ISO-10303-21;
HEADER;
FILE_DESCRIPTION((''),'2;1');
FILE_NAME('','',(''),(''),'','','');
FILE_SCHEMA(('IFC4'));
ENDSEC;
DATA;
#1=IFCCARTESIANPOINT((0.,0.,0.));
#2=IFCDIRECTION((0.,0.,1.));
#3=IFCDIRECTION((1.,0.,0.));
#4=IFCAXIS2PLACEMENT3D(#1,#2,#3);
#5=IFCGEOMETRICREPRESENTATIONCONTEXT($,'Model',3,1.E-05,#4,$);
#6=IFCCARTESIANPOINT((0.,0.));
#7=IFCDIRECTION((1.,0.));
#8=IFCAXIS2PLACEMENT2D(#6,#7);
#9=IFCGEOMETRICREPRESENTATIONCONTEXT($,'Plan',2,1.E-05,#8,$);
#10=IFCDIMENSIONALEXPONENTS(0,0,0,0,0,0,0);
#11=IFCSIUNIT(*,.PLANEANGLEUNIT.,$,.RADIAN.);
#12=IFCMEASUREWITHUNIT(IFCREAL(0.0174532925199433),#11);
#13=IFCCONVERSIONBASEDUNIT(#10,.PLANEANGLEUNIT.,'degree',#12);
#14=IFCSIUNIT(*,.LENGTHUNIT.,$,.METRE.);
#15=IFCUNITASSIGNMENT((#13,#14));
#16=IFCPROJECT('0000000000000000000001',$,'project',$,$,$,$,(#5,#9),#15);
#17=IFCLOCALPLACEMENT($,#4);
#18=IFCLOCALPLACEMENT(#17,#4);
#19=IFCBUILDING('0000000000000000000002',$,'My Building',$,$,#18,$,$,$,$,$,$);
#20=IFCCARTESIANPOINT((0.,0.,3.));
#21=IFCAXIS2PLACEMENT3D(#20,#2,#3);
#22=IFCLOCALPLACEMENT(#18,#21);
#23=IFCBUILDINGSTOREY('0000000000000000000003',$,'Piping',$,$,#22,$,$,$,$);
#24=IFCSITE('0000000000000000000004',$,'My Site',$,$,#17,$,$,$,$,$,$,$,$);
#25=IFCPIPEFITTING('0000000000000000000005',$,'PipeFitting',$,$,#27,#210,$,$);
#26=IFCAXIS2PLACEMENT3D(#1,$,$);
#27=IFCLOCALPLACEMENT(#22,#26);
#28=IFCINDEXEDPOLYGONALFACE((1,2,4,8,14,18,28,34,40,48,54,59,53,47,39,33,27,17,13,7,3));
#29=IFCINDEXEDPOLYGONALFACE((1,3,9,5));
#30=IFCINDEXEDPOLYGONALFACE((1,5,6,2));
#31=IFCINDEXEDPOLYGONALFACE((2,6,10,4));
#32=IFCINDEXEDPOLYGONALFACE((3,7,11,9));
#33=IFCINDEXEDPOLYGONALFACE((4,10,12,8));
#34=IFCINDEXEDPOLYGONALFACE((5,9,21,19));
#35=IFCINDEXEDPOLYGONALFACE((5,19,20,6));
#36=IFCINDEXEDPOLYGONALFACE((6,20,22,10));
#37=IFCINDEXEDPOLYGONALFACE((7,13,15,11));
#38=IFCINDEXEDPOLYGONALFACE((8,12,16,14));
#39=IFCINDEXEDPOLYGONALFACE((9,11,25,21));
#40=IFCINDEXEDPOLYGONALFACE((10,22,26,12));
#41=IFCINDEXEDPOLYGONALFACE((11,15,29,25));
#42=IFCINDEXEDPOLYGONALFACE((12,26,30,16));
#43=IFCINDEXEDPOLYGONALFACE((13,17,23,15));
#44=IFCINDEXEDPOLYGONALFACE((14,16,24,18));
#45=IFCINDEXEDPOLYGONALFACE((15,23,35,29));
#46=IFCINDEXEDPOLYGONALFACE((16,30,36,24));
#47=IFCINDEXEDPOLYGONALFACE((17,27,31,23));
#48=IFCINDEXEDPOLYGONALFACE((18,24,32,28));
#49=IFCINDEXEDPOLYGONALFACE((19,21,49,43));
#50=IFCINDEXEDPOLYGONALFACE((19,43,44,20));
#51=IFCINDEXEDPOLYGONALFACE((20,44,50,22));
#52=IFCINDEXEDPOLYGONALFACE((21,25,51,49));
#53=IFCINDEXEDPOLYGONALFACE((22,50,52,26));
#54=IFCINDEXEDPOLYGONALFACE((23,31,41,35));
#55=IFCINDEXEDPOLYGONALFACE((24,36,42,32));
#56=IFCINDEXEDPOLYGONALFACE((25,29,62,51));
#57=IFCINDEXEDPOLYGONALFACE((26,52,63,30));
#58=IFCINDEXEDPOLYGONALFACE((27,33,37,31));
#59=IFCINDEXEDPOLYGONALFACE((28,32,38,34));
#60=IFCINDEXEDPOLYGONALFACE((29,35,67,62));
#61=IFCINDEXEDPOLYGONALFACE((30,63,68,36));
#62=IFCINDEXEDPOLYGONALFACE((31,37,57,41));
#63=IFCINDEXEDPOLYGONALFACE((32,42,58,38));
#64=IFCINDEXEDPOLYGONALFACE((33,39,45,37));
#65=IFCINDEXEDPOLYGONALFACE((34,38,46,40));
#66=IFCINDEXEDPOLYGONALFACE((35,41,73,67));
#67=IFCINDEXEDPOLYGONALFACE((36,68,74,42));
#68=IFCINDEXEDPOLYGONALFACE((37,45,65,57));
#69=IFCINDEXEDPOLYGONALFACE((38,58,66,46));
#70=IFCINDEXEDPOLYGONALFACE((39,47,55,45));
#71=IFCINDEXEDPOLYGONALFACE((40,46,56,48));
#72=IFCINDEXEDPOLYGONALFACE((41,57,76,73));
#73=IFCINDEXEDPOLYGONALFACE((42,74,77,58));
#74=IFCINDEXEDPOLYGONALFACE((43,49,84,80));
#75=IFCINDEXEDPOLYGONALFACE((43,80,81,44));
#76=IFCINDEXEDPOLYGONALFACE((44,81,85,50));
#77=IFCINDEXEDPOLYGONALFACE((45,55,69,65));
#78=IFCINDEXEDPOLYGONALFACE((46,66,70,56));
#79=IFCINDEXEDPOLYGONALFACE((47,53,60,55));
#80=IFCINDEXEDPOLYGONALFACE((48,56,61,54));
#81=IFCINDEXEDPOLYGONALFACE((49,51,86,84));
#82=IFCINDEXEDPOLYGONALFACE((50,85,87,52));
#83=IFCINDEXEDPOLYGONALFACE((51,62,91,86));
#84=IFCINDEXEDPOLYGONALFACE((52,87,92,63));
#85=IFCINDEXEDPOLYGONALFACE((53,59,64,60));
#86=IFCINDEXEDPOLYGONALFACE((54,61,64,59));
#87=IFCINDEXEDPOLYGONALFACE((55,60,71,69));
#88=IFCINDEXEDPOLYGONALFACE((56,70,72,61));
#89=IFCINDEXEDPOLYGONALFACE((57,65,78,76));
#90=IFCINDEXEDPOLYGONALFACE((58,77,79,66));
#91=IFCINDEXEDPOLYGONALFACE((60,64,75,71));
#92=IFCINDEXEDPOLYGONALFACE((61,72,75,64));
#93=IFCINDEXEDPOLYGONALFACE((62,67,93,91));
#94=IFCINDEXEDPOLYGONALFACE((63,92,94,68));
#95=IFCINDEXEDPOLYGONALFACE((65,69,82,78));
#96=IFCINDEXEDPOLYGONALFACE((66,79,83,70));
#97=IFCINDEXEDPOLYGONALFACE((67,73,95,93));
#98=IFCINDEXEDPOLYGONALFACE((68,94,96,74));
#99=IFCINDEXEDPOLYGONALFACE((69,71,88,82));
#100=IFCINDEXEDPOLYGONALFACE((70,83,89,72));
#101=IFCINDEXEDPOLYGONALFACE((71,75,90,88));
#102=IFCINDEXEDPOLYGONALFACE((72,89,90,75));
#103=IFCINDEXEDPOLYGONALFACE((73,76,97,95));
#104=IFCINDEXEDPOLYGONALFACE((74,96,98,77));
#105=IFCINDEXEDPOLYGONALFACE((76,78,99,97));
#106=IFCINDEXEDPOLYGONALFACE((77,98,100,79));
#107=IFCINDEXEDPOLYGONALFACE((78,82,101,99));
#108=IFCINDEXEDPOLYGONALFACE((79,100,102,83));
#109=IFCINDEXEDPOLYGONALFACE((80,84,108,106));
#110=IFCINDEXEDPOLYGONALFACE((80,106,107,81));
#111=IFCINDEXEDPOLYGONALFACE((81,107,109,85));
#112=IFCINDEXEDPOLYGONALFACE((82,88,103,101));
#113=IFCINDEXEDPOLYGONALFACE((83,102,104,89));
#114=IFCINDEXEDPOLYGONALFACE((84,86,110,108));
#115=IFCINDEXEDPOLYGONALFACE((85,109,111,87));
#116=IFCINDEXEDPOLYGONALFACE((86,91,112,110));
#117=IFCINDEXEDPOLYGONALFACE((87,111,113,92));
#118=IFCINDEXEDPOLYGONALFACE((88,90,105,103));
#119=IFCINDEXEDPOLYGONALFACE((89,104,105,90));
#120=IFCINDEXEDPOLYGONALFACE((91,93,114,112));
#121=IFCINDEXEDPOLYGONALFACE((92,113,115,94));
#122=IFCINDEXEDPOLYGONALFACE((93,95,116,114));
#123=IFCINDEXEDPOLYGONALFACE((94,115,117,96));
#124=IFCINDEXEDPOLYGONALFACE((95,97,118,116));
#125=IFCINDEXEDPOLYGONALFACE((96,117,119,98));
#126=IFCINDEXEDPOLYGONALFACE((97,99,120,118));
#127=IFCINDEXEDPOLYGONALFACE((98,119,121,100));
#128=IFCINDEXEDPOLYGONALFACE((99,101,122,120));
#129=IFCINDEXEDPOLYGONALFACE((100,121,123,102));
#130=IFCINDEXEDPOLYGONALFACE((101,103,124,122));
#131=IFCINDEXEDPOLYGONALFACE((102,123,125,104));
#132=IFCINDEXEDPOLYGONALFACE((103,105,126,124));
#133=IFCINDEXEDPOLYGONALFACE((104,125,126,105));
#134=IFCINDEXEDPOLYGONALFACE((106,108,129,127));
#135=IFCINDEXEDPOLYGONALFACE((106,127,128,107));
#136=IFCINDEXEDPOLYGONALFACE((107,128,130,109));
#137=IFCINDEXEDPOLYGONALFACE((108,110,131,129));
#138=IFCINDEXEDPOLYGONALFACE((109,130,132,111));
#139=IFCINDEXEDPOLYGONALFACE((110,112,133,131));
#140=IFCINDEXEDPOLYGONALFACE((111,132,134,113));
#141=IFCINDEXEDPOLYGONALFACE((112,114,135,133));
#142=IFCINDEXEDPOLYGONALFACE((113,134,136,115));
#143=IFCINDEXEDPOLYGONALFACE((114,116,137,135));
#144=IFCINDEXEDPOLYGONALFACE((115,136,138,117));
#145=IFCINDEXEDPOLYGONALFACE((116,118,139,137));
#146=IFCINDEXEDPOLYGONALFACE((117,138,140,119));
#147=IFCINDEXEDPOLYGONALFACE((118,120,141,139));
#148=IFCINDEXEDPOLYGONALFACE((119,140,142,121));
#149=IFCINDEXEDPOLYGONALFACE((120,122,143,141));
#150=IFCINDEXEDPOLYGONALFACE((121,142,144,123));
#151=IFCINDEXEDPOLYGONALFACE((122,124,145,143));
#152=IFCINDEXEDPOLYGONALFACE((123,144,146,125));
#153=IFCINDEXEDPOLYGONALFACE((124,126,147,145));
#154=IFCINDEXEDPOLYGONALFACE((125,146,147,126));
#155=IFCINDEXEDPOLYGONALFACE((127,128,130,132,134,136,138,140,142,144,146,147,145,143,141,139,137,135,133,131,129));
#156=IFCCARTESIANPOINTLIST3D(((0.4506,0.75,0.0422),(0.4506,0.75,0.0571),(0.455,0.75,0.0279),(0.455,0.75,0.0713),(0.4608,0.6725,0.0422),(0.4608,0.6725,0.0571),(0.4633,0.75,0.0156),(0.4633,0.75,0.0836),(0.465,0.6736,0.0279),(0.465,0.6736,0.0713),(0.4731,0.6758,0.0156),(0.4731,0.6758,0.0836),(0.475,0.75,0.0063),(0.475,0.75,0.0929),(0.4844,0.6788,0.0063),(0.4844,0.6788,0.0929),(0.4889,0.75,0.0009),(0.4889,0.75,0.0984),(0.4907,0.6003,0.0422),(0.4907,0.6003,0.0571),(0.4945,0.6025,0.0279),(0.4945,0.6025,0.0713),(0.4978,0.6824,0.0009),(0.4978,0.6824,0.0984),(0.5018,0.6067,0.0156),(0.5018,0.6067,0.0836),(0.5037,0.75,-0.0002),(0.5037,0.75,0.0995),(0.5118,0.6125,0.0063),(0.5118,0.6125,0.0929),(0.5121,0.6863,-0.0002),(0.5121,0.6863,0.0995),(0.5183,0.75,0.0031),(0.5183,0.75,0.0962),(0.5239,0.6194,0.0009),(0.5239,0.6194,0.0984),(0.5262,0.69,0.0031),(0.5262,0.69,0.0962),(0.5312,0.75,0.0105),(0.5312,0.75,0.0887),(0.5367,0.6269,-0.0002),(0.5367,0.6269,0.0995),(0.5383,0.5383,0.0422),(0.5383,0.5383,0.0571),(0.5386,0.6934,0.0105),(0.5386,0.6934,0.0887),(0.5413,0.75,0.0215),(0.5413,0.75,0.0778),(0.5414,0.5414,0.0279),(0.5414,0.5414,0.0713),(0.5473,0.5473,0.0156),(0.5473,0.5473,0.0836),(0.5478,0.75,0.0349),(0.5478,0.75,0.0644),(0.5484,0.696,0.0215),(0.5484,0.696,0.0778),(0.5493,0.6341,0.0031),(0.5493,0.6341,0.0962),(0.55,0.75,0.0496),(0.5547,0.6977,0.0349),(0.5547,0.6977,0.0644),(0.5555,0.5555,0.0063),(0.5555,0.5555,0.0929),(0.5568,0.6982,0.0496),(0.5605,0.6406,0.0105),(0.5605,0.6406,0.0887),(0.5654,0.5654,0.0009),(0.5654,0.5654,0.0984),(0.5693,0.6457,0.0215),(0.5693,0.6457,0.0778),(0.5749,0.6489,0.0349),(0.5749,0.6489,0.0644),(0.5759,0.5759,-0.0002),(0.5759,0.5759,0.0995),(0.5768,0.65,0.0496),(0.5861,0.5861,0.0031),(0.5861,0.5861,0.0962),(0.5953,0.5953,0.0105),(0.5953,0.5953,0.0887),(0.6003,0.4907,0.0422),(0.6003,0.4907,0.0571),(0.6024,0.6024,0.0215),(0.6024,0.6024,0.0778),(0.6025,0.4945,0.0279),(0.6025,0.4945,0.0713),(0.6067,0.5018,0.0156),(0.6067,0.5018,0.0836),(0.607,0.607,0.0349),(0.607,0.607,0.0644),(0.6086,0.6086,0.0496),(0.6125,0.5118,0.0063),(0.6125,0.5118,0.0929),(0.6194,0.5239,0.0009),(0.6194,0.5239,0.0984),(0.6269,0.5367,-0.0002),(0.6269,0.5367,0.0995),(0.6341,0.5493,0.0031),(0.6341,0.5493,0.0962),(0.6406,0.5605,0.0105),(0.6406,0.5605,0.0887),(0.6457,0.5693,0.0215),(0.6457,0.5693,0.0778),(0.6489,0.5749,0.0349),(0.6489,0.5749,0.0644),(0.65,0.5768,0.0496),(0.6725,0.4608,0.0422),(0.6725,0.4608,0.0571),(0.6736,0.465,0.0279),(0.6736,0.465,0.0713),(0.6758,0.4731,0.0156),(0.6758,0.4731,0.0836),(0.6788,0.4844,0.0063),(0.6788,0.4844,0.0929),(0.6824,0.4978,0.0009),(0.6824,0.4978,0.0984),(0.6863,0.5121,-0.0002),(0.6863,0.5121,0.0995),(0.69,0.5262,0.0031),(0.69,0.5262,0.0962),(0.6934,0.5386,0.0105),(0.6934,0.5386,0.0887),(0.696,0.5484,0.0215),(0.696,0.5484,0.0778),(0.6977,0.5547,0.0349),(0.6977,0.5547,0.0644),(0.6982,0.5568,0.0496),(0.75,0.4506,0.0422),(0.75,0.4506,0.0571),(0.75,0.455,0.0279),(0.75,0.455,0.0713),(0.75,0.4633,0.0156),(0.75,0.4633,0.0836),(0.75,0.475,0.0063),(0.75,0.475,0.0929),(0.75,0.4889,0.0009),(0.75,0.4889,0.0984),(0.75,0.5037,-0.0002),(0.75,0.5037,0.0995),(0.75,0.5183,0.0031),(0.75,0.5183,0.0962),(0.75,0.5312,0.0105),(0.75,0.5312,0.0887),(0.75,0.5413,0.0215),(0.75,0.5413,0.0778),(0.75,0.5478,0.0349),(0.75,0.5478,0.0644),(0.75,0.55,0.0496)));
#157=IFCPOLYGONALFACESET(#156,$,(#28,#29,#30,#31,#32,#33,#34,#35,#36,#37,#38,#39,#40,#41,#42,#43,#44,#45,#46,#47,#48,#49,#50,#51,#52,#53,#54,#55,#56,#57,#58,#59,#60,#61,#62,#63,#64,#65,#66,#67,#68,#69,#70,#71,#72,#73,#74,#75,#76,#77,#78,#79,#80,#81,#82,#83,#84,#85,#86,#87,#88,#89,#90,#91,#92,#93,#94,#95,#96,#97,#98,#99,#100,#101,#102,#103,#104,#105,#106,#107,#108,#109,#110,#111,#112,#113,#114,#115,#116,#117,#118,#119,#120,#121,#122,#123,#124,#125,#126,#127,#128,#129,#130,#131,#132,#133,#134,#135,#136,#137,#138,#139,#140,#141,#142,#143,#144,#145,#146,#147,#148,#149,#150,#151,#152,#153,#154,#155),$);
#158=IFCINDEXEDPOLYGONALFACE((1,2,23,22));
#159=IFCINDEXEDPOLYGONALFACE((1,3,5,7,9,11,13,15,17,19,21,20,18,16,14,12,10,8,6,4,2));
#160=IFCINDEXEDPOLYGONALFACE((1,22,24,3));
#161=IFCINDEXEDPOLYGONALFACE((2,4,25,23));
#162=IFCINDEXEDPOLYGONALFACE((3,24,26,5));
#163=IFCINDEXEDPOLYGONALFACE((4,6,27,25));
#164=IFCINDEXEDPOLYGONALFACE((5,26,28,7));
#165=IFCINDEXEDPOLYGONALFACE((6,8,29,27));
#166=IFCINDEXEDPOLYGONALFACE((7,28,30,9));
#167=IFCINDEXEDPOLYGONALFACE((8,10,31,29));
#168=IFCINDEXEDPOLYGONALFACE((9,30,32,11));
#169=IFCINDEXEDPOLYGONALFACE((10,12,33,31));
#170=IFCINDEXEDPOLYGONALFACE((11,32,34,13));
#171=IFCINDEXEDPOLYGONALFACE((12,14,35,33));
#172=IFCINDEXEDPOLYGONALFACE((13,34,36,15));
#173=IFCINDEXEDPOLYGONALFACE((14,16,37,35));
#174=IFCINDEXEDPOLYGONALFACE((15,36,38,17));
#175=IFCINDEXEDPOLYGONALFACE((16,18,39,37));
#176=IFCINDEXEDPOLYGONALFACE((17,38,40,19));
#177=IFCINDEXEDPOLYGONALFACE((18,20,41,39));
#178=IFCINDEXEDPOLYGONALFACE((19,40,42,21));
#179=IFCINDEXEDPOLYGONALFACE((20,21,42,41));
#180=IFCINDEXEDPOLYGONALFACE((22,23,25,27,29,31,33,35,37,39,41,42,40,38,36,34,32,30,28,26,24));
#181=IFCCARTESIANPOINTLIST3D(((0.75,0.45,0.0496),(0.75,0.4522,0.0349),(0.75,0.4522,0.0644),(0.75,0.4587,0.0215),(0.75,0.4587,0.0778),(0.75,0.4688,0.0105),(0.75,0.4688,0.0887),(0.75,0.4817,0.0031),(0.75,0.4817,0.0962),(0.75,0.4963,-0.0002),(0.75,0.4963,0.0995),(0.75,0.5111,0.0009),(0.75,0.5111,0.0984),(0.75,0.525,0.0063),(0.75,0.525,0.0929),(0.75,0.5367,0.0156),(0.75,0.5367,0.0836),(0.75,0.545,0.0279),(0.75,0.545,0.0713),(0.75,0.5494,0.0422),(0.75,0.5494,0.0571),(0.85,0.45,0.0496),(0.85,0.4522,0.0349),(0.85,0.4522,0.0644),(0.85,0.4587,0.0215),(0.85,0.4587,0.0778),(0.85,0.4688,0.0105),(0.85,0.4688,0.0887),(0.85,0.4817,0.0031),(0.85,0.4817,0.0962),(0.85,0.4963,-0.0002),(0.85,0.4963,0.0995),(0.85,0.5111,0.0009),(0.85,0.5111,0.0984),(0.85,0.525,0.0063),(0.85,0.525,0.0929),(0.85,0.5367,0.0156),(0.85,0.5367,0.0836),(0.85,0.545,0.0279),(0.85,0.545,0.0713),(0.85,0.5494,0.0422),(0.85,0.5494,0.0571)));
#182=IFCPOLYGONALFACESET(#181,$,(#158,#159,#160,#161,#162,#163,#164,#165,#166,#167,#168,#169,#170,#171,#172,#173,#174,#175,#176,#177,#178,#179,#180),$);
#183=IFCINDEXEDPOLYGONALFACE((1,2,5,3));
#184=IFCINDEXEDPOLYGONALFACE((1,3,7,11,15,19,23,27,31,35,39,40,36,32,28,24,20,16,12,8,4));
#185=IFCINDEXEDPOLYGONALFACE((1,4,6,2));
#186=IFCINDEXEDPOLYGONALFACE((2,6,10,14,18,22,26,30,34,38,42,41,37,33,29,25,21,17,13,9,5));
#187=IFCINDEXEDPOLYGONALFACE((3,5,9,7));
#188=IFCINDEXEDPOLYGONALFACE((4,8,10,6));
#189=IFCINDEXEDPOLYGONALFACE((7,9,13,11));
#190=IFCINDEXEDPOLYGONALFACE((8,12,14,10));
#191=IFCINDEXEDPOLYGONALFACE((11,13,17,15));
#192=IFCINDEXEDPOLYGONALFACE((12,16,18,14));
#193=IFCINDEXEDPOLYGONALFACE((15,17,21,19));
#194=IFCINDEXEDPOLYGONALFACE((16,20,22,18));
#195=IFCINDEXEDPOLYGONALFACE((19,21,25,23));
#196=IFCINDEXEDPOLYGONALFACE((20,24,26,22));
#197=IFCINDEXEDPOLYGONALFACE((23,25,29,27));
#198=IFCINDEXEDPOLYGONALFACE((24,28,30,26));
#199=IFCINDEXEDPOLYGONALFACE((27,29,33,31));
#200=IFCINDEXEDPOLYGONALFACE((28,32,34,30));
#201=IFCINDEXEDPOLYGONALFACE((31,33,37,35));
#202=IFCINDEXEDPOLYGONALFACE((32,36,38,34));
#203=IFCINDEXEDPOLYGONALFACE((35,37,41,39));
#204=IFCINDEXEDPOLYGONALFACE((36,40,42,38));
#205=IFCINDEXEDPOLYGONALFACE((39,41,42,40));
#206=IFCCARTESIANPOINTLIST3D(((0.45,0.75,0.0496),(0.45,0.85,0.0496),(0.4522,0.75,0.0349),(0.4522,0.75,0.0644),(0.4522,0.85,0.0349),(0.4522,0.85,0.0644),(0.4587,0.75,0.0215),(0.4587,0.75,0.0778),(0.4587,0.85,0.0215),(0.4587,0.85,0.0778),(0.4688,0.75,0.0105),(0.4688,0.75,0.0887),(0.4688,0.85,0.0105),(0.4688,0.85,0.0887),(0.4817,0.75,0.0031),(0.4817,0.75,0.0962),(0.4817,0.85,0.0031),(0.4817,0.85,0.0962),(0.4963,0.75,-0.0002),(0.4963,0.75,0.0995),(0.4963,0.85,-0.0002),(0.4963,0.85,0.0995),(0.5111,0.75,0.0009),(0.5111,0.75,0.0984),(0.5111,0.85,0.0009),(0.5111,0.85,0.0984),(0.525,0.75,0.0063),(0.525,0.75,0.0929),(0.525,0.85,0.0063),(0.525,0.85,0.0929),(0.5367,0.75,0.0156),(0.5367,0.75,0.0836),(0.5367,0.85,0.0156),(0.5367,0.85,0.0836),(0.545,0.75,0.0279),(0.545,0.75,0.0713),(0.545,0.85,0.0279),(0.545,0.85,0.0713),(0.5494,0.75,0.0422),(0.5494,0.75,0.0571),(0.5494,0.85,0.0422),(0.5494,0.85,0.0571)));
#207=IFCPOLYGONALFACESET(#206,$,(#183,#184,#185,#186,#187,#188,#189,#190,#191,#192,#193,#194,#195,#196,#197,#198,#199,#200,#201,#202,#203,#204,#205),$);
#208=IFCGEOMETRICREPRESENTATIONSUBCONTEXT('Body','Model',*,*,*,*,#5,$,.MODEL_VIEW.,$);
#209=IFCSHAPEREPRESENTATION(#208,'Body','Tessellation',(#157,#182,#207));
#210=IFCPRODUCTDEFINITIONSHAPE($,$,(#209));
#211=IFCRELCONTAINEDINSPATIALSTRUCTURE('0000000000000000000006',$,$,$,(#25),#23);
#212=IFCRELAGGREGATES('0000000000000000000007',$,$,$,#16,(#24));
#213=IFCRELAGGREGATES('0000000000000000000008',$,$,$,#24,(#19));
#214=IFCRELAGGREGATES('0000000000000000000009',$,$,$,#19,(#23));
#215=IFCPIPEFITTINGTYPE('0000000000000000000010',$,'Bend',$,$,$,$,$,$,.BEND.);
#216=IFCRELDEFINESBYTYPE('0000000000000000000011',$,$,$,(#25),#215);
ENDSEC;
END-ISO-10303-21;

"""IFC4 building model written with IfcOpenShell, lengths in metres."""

from ifc_helpers import new_model, entity, si_unit, converted_unit, frame, origin_with_axes, origin_2d_with_axis, place, context, subcontext, project, spatial, circle, extrude, source, transform, mapped, type_object, type_shapes, element, save


model = new_model("IFC4")

# Units and contexts
model_context = context("Model", 3, precision=1e-05, world=origin_with_axes())
plan_context = context("Plan", 2, precision=1e-05, world=origin_2d_with_axis())
body_context = subcontext(model_context, "Body", "Model", "MODEL_VIEW")
ifc_project = project(units=[converted_unit("PLANEANGLEUNIT", "degree", entity("IfcReal", 0.0174532925199433), si_unit("PLANEANGLEUNIT", "RADIAN"), dimensions=[0, 0, 0, 0, 0, 0, 0]), si_unit("LENGTHUNIT", "METRE")], contexts=[model_context, plan_context])

# Site, building, storey
site_placement = place(None, origin_with_axes())
site = spatial("IfcSite", under=ifc_project, at=site_placement, Name="My Site")
building_placement = place(site_placement, origin_with_axes())
building = spatial("IfcBuilding", under=site, at=building_placement, Name="My Building")
storey_placement = place(building_placement, frame((0.0, 0.0, 3.0), z_axis=(0.0, 0.0, 1.0), x_axis=(1.0, 0.0, 0.0)))
storey = spatial("IfcBuildingStorey", under=building, at=storey_placement, Name="Piping")

# Pipe fitting
pipe_fitting_type_1 = type_object("IfcPipeFittingType", Name="Bend", PredefinedType="BEND")
shared_shape = source(origin_with_axes(), body_context, "Body", "SolidModel", [
    entity("IfcSweptDiskSolid", entity("IfcIndexedPolyCurve", entity("IfcCartesianPointList3D", [[0.0, 0.0, -0.1], [-0.0732, 0.0, -0.2768], [-0.25, 0.0, -0.35]]), [entity("IfcArcIndex", [1, 2, 3])]), 0.05),
    extrude(circle(Radius=0.05), origin_with_axes(), (0.0, 0.0, -1.0), 0.1),
    extrude(circle(Radius=0.05), frame((-0.25, 0.0, -0.35), z_axis=(-1.0, 0.0, 0.0), x_axis=(0.0, 0.0, -1.0)), (0.0, 0.0, 1.0), 0.1),
])
type_shapes(pipe_fitting_type_1, [shared_shape])
for number, where, z_axis, x_axis, name in (
    (1, (0.85, 0.5, 0.0496), (1.0, 0.000001, -0.000001), (0.000001, -1.0, 0.0), "PipeFitting"),
):
    element("IfcPipeFitting", number, at=place(storey_placement, frame(where, z_axis=z_axis, x_axis=x_axis)), inside=storey, type_object=pipe_fitting_type_1, Name=name, context=body_context, shape_type="MappedRepresentation", body=[
        mapped(shared_shape, transform((0.0, 0.0, 0.0), x_axis=(1.0, 0.0, 0.0), y_axis=(0.0, 1.0, 0.0), z_axis=(0.0, 0.0, 1.0), scale=1.0)),
    ])

save(model, "model.ifc")
